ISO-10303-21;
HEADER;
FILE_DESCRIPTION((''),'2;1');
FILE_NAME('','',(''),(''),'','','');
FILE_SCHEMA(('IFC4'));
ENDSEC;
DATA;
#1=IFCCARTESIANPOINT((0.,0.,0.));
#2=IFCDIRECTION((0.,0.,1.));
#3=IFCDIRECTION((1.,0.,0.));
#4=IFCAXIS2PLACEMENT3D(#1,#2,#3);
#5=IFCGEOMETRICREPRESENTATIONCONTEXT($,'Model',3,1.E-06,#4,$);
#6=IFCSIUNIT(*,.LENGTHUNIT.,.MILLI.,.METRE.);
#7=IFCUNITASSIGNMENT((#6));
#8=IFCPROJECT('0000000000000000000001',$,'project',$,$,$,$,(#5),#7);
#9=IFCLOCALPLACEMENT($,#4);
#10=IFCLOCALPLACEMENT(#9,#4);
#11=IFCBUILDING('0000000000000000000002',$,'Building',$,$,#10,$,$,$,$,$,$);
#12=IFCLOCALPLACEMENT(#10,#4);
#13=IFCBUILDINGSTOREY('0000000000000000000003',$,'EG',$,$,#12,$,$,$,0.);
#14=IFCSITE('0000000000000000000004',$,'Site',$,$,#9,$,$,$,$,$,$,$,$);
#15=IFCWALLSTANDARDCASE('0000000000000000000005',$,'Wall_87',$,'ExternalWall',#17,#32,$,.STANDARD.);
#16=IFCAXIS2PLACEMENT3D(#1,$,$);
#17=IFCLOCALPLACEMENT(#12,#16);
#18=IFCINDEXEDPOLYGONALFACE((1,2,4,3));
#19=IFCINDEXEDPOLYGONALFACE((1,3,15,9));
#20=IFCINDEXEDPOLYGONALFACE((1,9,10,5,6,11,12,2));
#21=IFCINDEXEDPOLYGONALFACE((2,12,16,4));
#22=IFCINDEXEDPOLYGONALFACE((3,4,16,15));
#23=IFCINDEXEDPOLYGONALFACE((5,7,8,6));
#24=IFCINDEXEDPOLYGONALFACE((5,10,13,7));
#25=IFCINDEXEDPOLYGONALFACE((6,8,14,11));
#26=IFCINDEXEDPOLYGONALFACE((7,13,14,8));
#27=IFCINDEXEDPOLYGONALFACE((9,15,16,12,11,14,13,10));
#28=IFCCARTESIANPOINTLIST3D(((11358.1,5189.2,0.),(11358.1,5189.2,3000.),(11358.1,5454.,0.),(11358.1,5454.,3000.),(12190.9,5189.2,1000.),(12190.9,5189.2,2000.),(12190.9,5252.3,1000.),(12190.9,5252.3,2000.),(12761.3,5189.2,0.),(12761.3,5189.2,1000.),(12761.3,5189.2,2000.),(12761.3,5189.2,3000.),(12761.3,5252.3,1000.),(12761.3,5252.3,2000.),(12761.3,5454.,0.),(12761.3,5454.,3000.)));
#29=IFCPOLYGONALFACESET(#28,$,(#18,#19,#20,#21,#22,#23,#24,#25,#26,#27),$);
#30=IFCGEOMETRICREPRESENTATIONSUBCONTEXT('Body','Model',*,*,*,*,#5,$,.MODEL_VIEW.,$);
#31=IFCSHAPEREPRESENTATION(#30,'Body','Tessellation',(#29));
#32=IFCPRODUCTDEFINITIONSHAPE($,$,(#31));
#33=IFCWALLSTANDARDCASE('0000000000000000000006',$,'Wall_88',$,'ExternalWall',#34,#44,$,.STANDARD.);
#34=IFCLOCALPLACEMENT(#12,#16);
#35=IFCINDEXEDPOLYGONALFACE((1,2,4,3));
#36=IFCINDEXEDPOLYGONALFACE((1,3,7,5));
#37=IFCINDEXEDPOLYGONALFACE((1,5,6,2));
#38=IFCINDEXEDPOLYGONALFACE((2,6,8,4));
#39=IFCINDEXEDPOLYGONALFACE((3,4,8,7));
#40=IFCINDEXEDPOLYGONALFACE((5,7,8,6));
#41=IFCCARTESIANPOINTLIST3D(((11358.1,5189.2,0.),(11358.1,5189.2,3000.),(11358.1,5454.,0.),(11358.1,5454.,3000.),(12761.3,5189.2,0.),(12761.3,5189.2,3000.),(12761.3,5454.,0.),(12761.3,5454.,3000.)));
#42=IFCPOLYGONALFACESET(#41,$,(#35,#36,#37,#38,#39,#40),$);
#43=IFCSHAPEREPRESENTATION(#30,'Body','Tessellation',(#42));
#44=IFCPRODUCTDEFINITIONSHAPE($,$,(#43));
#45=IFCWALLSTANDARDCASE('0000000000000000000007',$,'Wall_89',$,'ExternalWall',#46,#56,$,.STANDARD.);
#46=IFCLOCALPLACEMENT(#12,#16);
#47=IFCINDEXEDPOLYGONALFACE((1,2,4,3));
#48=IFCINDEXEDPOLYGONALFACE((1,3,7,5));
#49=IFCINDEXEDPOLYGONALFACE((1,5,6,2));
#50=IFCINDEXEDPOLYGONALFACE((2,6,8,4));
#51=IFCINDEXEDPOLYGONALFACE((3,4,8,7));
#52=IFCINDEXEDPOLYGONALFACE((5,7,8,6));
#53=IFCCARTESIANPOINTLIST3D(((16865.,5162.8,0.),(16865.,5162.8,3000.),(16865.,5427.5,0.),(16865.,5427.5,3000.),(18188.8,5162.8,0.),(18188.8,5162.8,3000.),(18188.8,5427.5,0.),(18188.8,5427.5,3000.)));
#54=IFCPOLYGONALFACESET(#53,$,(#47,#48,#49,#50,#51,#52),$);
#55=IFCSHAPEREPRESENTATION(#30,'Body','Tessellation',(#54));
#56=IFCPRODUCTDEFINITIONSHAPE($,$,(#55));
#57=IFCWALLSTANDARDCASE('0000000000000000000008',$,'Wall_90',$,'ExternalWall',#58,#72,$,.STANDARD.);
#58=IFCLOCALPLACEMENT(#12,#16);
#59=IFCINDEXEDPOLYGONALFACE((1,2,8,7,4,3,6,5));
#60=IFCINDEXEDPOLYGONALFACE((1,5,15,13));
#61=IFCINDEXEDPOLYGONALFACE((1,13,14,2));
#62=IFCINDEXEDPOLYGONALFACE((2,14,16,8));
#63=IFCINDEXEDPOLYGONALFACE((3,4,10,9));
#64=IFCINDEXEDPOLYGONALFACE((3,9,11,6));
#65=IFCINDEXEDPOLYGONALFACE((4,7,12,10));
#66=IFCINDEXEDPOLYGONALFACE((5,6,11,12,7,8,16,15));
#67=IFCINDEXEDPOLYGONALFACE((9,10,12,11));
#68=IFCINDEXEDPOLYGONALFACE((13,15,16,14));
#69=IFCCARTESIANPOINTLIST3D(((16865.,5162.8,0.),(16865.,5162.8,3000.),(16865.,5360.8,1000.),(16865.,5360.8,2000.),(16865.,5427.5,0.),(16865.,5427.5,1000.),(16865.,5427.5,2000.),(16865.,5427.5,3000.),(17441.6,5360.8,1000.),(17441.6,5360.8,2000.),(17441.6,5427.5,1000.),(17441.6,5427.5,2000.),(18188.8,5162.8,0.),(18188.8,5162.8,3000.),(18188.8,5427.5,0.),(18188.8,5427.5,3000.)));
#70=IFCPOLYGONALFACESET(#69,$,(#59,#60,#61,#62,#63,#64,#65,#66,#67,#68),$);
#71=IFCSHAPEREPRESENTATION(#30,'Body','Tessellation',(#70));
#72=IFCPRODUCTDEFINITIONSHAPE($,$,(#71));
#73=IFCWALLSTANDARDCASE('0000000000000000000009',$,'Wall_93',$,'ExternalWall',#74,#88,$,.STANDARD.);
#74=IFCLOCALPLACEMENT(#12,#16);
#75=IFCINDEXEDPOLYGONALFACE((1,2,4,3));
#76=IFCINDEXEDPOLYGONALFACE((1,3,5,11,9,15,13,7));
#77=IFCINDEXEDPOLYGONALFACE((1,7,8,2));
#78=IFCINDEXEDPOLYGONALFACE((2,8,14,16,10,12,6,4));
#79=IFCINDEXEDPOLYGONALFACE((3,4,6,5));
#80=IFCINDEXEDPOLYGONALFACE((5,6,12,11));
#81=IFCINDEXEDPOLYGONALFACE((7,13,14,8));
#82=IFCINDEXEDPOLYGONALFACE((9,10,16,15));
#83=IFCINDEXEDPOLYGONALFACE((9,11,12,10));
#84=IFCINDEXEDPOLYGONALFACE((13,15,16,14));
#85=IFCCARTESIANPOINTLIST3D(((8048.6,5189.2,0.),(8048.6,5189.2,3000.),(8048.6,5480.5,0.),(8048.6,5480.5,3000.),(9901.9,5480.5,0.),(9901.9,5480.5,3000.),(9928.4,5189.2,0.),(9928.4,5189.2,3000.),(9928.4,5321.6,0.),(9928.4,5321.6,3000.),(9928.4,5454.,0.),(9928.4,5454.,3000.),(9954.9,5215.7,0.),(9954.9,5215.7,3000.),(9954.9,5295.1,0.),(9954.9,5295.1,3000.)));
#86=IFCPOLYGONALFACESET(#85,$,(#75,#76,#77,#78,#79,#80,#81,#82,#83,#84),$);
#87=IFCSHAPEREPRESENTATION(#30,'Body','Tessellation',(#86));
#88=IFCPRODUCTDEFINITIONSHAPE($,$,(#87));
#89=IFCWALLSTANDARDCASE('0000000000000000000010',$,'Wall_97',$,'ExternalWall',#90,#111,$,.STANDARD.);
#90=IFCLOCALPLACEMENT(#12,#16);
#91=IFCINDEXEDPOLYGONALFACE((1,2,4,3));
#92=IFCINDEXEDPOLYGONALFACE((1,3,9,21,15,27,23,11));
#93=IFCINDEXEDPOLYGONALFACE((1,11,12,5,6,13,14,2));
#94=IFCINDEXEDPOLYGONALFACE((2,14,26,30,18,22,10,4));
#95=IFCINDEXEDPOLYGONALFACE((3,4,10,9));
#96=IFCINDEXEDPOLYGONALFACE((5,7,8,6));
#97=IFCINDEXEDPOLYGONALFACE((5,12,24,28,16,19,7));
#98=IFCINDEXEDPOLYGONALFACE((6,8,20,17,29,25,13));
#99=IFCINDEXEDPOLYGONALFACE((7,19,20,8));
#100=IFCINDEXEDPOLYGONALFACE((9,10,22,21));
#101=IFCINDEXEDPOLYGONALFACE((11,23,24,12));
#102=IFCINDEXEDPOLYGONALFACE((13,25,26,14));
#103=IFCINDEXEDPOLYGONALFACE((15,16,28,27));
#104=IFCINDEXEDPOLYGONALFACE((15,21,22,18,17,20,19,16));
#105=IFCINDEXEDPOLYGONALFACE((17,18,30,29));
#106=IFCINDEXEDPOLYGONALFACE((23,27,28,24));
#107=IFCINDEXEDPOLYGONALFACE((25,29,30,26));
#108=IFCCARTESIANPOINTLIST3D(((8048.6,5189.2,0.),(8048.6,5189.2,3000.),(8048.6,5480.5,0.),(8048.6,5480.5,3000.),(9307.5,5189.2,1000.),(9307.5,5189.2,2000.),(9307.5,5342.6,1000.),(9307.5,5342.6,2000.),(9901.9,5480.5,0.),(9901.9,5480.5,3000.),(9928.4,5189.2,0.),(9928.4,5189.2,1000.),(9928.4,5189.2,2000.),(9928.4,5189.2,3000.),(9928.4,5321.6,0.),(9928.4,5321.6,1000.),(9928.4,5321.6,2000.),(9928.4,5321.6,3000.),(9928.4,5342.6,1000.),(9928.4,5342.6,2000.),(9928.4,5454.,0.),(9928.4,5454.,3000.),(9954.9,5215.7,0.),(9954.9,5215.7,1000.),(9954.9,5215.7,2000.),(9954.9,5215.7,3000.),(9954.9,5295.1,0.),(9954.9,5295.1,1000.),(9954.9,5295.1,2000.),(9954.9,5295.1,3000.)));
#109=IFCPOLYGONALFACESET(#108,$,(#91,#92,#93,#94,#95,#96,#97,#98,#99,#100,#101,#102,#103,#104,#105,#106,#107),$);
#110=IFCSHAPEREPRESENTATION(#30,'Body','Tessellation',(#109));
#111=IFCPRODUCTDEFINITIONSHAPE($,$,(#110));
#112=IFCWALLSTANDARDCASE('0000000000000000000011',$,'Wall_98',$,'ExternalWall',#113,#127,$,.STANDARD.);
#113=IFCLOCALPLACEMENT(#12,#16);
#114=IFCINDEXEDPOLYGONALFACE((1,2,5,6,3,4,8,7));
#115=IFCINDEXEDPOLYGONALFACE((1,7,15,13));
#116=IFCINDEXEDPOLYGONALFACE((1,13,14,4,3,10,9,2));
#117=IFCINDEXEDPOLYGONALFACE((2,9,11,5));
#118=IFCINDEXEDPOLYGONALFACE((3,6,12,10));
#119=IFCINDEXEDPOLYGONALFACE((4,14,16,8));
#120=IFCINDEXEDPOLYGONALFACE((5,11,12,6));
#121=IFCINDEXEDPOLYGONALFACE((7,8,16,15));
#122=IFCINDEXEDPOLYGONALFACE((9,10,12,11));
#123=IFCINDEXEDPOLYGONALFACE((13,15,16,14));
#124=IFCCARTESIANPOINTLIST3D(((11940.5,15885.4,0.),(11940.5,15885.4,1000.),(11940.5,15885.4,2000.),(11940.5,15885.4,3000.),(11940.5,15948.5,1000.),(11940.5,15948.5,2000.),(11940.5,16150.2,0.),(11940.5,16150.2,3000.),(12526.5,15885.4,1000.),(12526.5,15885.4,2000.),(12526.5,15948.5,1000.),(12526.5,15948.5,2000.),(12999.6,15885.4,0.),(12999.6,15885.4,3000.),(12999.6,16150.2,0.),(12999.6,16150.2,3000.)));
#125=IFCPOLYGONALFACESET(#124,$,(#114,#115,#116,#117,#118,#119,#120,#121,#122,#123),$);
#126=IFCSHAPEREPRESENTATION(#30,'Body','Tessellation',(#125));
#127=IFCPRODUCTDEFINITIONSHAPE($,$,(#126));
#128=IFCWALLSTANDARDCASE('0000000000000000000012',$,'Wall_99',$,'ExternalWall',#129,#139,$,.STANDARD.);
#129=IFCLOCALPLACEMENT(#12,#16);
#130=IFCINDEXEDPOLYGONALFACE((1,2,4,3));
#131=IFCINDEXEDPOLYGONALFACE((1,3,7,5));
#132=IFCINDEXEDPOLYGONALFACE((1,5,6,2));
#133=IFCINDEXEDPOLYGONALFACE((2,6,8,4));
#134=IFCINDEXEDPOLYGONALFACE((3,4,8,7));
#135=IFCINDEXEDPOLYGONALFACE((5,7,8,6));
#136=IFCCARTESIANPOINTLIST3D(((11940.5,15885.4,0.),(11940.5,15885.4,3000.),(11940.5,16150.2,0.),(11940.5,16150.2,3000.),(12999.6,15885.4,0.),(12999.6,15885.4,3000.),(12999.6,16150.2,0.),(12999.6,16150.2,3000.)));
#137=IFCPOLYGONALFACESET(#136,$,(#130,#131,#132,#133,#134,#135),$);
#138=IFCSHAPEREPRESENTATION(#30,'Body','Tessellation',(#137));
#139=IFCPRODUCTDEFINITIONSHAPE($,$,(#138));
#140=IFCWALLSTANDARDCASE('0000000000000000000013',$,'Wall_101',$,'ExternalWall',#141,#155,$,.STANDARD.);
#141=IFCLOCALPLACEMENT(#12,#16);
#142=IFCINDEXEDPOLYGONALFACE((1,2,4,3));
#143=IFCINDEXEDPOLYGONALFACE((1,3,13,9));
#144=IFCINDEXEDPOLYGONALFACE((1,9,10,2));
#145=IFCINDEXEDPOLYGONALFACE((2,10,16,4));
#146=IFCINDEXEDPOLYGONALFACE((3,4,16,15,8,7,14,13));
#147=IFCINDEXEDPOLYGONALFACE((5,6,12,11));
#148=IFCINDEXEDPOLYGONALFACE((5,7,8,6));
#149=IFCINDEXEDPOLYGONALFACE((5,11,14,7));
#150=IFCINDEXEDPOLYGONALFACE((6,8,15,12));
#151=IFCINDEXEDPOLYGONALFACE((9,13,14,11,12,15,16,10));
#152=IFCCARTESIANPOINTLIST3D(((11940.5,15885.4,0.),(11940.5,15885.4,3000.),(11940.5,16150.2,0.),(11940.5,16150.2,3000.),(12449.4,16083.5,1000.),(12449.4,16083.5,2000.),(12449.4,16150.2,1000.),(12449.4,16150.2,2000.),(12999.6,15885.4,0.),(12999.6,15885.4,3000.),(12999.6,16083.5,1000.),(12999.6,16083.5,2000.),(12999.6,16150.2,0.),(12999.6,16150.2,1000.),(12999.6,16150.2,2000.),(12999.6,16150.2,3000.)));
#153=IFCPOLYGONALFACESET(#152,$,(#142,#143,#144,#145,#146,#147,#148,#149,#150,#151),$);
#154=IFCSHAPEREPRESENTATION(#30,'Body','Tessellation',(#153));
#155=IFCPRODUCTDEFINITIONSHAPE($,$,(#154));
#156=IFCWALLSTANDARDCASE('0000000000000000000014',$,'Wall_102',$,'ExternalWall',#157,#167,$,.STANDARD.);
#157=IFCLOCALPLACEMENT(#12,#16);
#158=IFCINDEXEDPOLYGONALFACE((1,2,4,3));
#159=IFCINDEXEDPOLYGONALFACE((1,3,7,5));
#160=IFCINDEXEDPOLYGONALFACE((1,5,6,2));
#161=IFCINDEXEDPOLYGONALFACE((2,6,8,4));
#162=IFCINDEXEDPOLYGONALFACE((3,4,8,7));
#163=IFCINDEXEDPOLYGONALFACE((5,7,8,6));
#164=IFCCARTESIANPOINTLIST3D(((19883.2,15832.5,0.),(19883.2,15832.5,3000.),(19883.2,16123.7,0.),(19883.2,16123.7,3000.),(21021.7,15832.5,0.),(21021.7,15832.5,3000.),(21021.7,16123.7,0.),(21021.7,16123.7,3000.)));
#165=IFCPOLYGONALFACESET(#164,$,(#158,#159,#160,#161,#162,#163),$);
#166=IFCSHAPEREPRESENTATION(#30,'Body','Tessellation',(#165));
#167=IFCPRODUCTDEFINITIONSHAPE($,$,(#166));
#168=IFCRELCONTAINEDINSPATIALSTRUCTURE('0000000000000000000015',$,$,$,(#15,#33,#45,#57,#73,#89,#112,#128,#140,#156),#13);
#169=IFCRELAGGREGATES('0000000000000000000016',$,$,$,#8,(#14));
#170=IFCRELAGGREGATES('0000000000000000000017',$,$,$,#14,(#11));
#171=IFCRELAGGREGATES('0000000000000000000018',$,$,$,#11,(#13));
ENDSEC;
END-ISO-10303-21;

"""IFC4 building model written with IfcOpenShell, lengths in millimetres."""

from ifc_helpers import new_model, si_unit, frame, origin_with_axes, place, context, subcontext, project, spatial, polyline, rectangle, outline, extrude, element, save


model = new_model("IFC4")

# Units and contexts
model_context = context("Model", 3, precision=1e-06, world=origin_with_axes())
body_context = subcontext(model_context, "Body", "Model", "MODEL_VIEW")
ifc_project = project(units=[si_unit("LENGTHUNIT", "METRE", prefix="MILLI")], contexts=[model_context])

# Site, building, storey
site_placement = place(None, origin_with_axes())
site = spatial("IfcSite", under=ifc_project, at=site_placement, Name="Site")
building_placement = place(site_placement, origin_with_axes())
building = spatial("IfcBuilding", under=site, at=building_placement, Name="Building")
storey_placement = place(building_placement, origin_with_axes())
storey = spatial("IfcBuildingStorey", under=building, at=storey_placement, Name="EG", Elevation=0.0)

# Wall, opening
wall_1_placement = place(storey_placement, origin_with_axes())
wall_1 = element("IfcWallStandardCase", 1, at=wall_1_placement, inside=storey, Name="Wall_87", ObjectType="ExternalWall", PredefinedType="STANDARD", context=body_context, shape_type="SweptSolid", body=[
    extrude(outline(polyline([(11358.1, 5189.2, 0.0), (11358.1, 5454.0, 0.0), (12761.3, 5454.0, 0.0), (12761.3, 5189.2, 0.0), (11358.1, 5189.2, 0.0)])), origin_with_axes(), (0.0, 0.0, 1.0), 3000.0),
])
opening_1_placement = place(wall_1_placement, origin_with_axes())
element("IfcOpeningElement", 2, at=opening_1_placement, inside=storey, cuts=wall_1, context=body_context, shape_type="SweptSolid", body=[
    extrude(rectangle(XDim=1123.3, YDim=115.0), frame((12752.5, 5194.8, 1000.0), z_axis=(0.0, 0.0, 1.0), x_axis=(1.0, 0.0, 0.0)), (0.0, 0.0, 1.0), 1000.0),
])

# Walls
wall_2_placement = place(storey_placement, origin_with_axes())
element("IfcWallStandardCase", 3, at=wall_2_placement, inside=storey, Name="Wall_88", ObjectType="ExternalWall", PredefinedType="STANDARD", context=body_context, shape_type="SweptSolid", body=[
    extrude(outline(polyline([(11358.1, 5189.2, 0.0), (11358.1, 5454.0, 0.0), (12761.3, 5454.0, 0.0), (12761.3, 5189.2, 0.0), (11358.1, 5189.2, 0.0)])), origin_with_axes(), (0.0, 0.0, 1.0), 3000.0),
])
wall_3_placement = place(storey_placement, origin_with_axes())
element("IfcWallStandardCase", 4, at=wall_3_placement, inside=storey, Name="Wall_89", ObjectType="ExternalWall", PredefinedType="STANDARD", context=body_context, shape_type="SweptSolid", body=[
    extrude(outline(polyline([(16865.0, 5162.8, 0.0), (16865.0, 5427.5, 0.0), (18188.8, 5427.5, 0.0), (18188.8, 5162.8, 0.0), (16865.0, 5162.8, 0.0)])), origin_with_axes(), (0.0, 0.0, 1.0), 3000.0),
])

# Wall, opening
wall_4_placement = place(storey_placement, origin_with_axes())
wall_4 = element("IfcWallStandardCase", 5, at=wall_4_placement, inside=storey, Name="Wall_90", ObjectType="ExternalWall", PredefinedType="STANDARD", context=body_context, shape_type="SweptSolid", body=[
    extrude(outline(polyline([(16865.0, 5162.8, 0.0), (16865.0, 5427.5, 0.0), (18188.8, 5427.5, 0.0), (18188.8, 5162.8, 0.0), (16865.0, 5162.8, 0.0)])), origin_with_axes(), (0.0, 0.0, 1.0), 3000.0),
])
opening_2_placement = place(wall_4_placement, origin_with_axes())
element("IfcOpeningElement", 6, at=opening_2_placement, inside=storey, cuts=wall_4, context=body_context, shape_type="SweptSolid", body=[
    extrude(rectangle(XDim=1142.0, YDim=115.0), frame((16870.6, 5418.3, 1000.0), z_axis=(0.0, 0.0, 1.0), x_axis=(1.0, 0.0, 0.0)), (0.0, 0.0, 1.0), 1000.0),
])

# Wall
for number, where, z_axis, x_axis, name in (
    (7, (0.0, 0.0, 0.0), (0.0, 0.0, 1.0), (1.0, 0.0, 0.0), "Wall_93"),
):
    element("IfcWallStandardCase", number, at=place(storey_placement, frame(where, z_axis=z_axis, x_axis=x_axis)), inside=storey, Name=name, ObjectType="ExternalWall", PredefinedType="STANDARD", context=body_context, shape_type="SweptSolid", body=[
        extrude(outline(polyline([(8048.6, 5189.2, 0.0), (8048.6, 5480.5, 0.0), (9901.9, 5480.5, 0.0), (9928.4, 5454.0, 0.0), (9928.4, 5321.6, 0.0), (9954.9, 5295.1, 0.0), (9954.9, 5215.7, 0.0), (9928.4, 5189.2, 0.0), (8048.6, 5189.2, 0.0)])), origin_with_axes(), (0.0, 0.0, 1.0), 3000.0),
    ])

# Walls, openings
wall_5_placement = place(storey_placement, origin_with_axes())
wall_5 = element("IfcWallStandardCase", 8, at=wall_5_placement, inside=storey, Name="Wall_97", ObjectType="ExternalWall", PredefinedType="STANDARD", context=body_context, shape_type="SweptSolid", body=[
    extrude(outline(polyline([(8048.6, 5189.2, 0.0), (8048.6, 5480.5, 0.0), (9901.9, 5480.5, 0.0), (9928.4, 5454.0, 0.0), (9928.4, 5321.6, 0.0), (9954.9, 5295.1, 0.0), (9954.9, 5215.7, 0.0), (9928.4, 5189.2, 0.0), (8048.6, 5189.2, 0.0)])), origin_with_axes(), (0.0, 0.0, 1.0), 3000.0),
])
opening_3_placement = place(wall_5_placement, origin_with_axes())
element("IfcOpeningElement", 9, at=opening_3_placement, inside=storey, cuts=wall_5, context=body_context, shape_type="SweptSolid", body=[
    extrude(rectangle(XDim=1215.6, YDim=240.0), frame((9915.3, 5222.6, 1000.0), z_axis=(0.0, 0.0, 1.0), x_axis=(1.0, 0.0, 0.0)), (0.0, 0.0, 1.0), 1000.0),
])
wall_6_placement = place(storey_placement, origin_with_axes())
wall_6 = element("IfcWallStandardCase", 10, at=wall_6_placement, inside=storey, Name="Wall_98", ObjectType="ExternalWall", PredefinedType="STANDARD", context=body_context, shape_type="SweptSolid", body=[
    extrude(outline(polyline([(11940.5, 15885.4, 0.0), (11940.5, 16150.2, 0.0), (12999.6, 16150.2, 0.0), (12999.6, 15885.4, 0.0), (11940.5, 15885.4, 0.0)])), origin_with_axes(), (0.0, 0.0, 1.0), 3000.0),
])
opening_4_placement = place(wall_6_placement, origin_with_axes())
element("IfcOpeningElement", 11, at=opening_4_placement, inside=storey, cuts=wall_6, context=body_context, shape_type="SweptSolid", body=[
    extrude(rectangle(XDim=1160.7, YDim=115.0), frame((11946.1, 15891.0, 1000.0), z_axis=(0.0, 0.0, 1.0), x_axis=(1.0, 0.0, 0.0)), (0.0, 0.0, 1.0), 1000.0),
])

# Wall
for number, where, z_axis, x_axis, name in (
    (12, (0.0, 0.0, 0.0), (0.0, 0.0, 1.0), (1.0, 0.0, 0.0), "Wall_99"),
):
    element("IfcWallStandardCase", number, at=place(storey_placement, frame(where, z_axis=z_axis, x_axis=x_axis)), inside=storey, Name=name, ObjectType="ExternalWall", PredefinedType="STANDARD", context=body_context, shape_type="SweptSolid", body=[
        extrude(outline(polyline([(11940.5, 15885.4, 0.0), (11940.5, 16150.2, 0.0), (12999.6, 16150.2, 0.0), (12999.6, 15885.4, 0.0), (11940.5, 15885.4, 0.0)])), origin_with_axes(), (0.0, 0.0, 1.0), 3000.0),
    ])

# Wall, opening
wall_7_placement = place(storey_placement, origin_with_axes())
wall_7 = element("IfcWallStandardCase", 13, at=wall_7_placement, inside=storey, Name="Wall_101", ObjectType="ExternalWall", PredefinedType="STANDARD", context=body_context, shape_type="SweptSolid", body=[
    extrude(outline(polyline([(11940.5, 15885.4, 0.0), (11940.5, 16150.2, 0.0), (12999.6, 16150.2, 0.0), (12999.6, 15885.4, 0.0), (11940.5, 15885.4, 0.0)])), origin_with_axes(), (0.0, 0.0, 1.0), 3000.0),
])
opening_5_placement = place(wall_7_placement, origin_with_axes())
element("IfcOpeningElement", 14, at=opening_5_placement, inside=storey, cuts=wall_7, context=body_context, shape_type="SweptSolid", body=[
    extrude(rectangle(XDim=1104.5, YDim=115.0), frame((13001.7, 16141.0, 1000.0), z_axis=(0.0, 0.0, 1.0), x_axis=(1.0, 0.0, 0.0)), (0.0, 0.0, 1.0), 1000.0),
])

# Wall
for number, where, z_axis, x_axis, name in (
    (15, (0.0, 0.0, 0.0), (0.0, 0.0, 1.0), (1.0, 0.0, 0.0), "Wall_102"),
):
    element("IfcWallStandardCase", number, at=place(storey_placement, frame(where, z_axis=z_axis, x_axis=x_axis)), inside=storey, Name=name, ObjectType="ExternalWall", PredefinedType="STANDARD", context=body_context, shape_type="SweptSolid", body=[
        extrude(outline(polyline([(19883.2, 15832.5, 0.0), (19883.2, 16123.7, 0.0), (21021.7, 16123.7, 0.0), (21021.7, 15832.5, 0.0), (19883.2, 15832.5, 0.0)])), origin_with_axes(), (0.0, 0.0, 1.0), 3000.0),
    ])

save(model, "model.ifc")
